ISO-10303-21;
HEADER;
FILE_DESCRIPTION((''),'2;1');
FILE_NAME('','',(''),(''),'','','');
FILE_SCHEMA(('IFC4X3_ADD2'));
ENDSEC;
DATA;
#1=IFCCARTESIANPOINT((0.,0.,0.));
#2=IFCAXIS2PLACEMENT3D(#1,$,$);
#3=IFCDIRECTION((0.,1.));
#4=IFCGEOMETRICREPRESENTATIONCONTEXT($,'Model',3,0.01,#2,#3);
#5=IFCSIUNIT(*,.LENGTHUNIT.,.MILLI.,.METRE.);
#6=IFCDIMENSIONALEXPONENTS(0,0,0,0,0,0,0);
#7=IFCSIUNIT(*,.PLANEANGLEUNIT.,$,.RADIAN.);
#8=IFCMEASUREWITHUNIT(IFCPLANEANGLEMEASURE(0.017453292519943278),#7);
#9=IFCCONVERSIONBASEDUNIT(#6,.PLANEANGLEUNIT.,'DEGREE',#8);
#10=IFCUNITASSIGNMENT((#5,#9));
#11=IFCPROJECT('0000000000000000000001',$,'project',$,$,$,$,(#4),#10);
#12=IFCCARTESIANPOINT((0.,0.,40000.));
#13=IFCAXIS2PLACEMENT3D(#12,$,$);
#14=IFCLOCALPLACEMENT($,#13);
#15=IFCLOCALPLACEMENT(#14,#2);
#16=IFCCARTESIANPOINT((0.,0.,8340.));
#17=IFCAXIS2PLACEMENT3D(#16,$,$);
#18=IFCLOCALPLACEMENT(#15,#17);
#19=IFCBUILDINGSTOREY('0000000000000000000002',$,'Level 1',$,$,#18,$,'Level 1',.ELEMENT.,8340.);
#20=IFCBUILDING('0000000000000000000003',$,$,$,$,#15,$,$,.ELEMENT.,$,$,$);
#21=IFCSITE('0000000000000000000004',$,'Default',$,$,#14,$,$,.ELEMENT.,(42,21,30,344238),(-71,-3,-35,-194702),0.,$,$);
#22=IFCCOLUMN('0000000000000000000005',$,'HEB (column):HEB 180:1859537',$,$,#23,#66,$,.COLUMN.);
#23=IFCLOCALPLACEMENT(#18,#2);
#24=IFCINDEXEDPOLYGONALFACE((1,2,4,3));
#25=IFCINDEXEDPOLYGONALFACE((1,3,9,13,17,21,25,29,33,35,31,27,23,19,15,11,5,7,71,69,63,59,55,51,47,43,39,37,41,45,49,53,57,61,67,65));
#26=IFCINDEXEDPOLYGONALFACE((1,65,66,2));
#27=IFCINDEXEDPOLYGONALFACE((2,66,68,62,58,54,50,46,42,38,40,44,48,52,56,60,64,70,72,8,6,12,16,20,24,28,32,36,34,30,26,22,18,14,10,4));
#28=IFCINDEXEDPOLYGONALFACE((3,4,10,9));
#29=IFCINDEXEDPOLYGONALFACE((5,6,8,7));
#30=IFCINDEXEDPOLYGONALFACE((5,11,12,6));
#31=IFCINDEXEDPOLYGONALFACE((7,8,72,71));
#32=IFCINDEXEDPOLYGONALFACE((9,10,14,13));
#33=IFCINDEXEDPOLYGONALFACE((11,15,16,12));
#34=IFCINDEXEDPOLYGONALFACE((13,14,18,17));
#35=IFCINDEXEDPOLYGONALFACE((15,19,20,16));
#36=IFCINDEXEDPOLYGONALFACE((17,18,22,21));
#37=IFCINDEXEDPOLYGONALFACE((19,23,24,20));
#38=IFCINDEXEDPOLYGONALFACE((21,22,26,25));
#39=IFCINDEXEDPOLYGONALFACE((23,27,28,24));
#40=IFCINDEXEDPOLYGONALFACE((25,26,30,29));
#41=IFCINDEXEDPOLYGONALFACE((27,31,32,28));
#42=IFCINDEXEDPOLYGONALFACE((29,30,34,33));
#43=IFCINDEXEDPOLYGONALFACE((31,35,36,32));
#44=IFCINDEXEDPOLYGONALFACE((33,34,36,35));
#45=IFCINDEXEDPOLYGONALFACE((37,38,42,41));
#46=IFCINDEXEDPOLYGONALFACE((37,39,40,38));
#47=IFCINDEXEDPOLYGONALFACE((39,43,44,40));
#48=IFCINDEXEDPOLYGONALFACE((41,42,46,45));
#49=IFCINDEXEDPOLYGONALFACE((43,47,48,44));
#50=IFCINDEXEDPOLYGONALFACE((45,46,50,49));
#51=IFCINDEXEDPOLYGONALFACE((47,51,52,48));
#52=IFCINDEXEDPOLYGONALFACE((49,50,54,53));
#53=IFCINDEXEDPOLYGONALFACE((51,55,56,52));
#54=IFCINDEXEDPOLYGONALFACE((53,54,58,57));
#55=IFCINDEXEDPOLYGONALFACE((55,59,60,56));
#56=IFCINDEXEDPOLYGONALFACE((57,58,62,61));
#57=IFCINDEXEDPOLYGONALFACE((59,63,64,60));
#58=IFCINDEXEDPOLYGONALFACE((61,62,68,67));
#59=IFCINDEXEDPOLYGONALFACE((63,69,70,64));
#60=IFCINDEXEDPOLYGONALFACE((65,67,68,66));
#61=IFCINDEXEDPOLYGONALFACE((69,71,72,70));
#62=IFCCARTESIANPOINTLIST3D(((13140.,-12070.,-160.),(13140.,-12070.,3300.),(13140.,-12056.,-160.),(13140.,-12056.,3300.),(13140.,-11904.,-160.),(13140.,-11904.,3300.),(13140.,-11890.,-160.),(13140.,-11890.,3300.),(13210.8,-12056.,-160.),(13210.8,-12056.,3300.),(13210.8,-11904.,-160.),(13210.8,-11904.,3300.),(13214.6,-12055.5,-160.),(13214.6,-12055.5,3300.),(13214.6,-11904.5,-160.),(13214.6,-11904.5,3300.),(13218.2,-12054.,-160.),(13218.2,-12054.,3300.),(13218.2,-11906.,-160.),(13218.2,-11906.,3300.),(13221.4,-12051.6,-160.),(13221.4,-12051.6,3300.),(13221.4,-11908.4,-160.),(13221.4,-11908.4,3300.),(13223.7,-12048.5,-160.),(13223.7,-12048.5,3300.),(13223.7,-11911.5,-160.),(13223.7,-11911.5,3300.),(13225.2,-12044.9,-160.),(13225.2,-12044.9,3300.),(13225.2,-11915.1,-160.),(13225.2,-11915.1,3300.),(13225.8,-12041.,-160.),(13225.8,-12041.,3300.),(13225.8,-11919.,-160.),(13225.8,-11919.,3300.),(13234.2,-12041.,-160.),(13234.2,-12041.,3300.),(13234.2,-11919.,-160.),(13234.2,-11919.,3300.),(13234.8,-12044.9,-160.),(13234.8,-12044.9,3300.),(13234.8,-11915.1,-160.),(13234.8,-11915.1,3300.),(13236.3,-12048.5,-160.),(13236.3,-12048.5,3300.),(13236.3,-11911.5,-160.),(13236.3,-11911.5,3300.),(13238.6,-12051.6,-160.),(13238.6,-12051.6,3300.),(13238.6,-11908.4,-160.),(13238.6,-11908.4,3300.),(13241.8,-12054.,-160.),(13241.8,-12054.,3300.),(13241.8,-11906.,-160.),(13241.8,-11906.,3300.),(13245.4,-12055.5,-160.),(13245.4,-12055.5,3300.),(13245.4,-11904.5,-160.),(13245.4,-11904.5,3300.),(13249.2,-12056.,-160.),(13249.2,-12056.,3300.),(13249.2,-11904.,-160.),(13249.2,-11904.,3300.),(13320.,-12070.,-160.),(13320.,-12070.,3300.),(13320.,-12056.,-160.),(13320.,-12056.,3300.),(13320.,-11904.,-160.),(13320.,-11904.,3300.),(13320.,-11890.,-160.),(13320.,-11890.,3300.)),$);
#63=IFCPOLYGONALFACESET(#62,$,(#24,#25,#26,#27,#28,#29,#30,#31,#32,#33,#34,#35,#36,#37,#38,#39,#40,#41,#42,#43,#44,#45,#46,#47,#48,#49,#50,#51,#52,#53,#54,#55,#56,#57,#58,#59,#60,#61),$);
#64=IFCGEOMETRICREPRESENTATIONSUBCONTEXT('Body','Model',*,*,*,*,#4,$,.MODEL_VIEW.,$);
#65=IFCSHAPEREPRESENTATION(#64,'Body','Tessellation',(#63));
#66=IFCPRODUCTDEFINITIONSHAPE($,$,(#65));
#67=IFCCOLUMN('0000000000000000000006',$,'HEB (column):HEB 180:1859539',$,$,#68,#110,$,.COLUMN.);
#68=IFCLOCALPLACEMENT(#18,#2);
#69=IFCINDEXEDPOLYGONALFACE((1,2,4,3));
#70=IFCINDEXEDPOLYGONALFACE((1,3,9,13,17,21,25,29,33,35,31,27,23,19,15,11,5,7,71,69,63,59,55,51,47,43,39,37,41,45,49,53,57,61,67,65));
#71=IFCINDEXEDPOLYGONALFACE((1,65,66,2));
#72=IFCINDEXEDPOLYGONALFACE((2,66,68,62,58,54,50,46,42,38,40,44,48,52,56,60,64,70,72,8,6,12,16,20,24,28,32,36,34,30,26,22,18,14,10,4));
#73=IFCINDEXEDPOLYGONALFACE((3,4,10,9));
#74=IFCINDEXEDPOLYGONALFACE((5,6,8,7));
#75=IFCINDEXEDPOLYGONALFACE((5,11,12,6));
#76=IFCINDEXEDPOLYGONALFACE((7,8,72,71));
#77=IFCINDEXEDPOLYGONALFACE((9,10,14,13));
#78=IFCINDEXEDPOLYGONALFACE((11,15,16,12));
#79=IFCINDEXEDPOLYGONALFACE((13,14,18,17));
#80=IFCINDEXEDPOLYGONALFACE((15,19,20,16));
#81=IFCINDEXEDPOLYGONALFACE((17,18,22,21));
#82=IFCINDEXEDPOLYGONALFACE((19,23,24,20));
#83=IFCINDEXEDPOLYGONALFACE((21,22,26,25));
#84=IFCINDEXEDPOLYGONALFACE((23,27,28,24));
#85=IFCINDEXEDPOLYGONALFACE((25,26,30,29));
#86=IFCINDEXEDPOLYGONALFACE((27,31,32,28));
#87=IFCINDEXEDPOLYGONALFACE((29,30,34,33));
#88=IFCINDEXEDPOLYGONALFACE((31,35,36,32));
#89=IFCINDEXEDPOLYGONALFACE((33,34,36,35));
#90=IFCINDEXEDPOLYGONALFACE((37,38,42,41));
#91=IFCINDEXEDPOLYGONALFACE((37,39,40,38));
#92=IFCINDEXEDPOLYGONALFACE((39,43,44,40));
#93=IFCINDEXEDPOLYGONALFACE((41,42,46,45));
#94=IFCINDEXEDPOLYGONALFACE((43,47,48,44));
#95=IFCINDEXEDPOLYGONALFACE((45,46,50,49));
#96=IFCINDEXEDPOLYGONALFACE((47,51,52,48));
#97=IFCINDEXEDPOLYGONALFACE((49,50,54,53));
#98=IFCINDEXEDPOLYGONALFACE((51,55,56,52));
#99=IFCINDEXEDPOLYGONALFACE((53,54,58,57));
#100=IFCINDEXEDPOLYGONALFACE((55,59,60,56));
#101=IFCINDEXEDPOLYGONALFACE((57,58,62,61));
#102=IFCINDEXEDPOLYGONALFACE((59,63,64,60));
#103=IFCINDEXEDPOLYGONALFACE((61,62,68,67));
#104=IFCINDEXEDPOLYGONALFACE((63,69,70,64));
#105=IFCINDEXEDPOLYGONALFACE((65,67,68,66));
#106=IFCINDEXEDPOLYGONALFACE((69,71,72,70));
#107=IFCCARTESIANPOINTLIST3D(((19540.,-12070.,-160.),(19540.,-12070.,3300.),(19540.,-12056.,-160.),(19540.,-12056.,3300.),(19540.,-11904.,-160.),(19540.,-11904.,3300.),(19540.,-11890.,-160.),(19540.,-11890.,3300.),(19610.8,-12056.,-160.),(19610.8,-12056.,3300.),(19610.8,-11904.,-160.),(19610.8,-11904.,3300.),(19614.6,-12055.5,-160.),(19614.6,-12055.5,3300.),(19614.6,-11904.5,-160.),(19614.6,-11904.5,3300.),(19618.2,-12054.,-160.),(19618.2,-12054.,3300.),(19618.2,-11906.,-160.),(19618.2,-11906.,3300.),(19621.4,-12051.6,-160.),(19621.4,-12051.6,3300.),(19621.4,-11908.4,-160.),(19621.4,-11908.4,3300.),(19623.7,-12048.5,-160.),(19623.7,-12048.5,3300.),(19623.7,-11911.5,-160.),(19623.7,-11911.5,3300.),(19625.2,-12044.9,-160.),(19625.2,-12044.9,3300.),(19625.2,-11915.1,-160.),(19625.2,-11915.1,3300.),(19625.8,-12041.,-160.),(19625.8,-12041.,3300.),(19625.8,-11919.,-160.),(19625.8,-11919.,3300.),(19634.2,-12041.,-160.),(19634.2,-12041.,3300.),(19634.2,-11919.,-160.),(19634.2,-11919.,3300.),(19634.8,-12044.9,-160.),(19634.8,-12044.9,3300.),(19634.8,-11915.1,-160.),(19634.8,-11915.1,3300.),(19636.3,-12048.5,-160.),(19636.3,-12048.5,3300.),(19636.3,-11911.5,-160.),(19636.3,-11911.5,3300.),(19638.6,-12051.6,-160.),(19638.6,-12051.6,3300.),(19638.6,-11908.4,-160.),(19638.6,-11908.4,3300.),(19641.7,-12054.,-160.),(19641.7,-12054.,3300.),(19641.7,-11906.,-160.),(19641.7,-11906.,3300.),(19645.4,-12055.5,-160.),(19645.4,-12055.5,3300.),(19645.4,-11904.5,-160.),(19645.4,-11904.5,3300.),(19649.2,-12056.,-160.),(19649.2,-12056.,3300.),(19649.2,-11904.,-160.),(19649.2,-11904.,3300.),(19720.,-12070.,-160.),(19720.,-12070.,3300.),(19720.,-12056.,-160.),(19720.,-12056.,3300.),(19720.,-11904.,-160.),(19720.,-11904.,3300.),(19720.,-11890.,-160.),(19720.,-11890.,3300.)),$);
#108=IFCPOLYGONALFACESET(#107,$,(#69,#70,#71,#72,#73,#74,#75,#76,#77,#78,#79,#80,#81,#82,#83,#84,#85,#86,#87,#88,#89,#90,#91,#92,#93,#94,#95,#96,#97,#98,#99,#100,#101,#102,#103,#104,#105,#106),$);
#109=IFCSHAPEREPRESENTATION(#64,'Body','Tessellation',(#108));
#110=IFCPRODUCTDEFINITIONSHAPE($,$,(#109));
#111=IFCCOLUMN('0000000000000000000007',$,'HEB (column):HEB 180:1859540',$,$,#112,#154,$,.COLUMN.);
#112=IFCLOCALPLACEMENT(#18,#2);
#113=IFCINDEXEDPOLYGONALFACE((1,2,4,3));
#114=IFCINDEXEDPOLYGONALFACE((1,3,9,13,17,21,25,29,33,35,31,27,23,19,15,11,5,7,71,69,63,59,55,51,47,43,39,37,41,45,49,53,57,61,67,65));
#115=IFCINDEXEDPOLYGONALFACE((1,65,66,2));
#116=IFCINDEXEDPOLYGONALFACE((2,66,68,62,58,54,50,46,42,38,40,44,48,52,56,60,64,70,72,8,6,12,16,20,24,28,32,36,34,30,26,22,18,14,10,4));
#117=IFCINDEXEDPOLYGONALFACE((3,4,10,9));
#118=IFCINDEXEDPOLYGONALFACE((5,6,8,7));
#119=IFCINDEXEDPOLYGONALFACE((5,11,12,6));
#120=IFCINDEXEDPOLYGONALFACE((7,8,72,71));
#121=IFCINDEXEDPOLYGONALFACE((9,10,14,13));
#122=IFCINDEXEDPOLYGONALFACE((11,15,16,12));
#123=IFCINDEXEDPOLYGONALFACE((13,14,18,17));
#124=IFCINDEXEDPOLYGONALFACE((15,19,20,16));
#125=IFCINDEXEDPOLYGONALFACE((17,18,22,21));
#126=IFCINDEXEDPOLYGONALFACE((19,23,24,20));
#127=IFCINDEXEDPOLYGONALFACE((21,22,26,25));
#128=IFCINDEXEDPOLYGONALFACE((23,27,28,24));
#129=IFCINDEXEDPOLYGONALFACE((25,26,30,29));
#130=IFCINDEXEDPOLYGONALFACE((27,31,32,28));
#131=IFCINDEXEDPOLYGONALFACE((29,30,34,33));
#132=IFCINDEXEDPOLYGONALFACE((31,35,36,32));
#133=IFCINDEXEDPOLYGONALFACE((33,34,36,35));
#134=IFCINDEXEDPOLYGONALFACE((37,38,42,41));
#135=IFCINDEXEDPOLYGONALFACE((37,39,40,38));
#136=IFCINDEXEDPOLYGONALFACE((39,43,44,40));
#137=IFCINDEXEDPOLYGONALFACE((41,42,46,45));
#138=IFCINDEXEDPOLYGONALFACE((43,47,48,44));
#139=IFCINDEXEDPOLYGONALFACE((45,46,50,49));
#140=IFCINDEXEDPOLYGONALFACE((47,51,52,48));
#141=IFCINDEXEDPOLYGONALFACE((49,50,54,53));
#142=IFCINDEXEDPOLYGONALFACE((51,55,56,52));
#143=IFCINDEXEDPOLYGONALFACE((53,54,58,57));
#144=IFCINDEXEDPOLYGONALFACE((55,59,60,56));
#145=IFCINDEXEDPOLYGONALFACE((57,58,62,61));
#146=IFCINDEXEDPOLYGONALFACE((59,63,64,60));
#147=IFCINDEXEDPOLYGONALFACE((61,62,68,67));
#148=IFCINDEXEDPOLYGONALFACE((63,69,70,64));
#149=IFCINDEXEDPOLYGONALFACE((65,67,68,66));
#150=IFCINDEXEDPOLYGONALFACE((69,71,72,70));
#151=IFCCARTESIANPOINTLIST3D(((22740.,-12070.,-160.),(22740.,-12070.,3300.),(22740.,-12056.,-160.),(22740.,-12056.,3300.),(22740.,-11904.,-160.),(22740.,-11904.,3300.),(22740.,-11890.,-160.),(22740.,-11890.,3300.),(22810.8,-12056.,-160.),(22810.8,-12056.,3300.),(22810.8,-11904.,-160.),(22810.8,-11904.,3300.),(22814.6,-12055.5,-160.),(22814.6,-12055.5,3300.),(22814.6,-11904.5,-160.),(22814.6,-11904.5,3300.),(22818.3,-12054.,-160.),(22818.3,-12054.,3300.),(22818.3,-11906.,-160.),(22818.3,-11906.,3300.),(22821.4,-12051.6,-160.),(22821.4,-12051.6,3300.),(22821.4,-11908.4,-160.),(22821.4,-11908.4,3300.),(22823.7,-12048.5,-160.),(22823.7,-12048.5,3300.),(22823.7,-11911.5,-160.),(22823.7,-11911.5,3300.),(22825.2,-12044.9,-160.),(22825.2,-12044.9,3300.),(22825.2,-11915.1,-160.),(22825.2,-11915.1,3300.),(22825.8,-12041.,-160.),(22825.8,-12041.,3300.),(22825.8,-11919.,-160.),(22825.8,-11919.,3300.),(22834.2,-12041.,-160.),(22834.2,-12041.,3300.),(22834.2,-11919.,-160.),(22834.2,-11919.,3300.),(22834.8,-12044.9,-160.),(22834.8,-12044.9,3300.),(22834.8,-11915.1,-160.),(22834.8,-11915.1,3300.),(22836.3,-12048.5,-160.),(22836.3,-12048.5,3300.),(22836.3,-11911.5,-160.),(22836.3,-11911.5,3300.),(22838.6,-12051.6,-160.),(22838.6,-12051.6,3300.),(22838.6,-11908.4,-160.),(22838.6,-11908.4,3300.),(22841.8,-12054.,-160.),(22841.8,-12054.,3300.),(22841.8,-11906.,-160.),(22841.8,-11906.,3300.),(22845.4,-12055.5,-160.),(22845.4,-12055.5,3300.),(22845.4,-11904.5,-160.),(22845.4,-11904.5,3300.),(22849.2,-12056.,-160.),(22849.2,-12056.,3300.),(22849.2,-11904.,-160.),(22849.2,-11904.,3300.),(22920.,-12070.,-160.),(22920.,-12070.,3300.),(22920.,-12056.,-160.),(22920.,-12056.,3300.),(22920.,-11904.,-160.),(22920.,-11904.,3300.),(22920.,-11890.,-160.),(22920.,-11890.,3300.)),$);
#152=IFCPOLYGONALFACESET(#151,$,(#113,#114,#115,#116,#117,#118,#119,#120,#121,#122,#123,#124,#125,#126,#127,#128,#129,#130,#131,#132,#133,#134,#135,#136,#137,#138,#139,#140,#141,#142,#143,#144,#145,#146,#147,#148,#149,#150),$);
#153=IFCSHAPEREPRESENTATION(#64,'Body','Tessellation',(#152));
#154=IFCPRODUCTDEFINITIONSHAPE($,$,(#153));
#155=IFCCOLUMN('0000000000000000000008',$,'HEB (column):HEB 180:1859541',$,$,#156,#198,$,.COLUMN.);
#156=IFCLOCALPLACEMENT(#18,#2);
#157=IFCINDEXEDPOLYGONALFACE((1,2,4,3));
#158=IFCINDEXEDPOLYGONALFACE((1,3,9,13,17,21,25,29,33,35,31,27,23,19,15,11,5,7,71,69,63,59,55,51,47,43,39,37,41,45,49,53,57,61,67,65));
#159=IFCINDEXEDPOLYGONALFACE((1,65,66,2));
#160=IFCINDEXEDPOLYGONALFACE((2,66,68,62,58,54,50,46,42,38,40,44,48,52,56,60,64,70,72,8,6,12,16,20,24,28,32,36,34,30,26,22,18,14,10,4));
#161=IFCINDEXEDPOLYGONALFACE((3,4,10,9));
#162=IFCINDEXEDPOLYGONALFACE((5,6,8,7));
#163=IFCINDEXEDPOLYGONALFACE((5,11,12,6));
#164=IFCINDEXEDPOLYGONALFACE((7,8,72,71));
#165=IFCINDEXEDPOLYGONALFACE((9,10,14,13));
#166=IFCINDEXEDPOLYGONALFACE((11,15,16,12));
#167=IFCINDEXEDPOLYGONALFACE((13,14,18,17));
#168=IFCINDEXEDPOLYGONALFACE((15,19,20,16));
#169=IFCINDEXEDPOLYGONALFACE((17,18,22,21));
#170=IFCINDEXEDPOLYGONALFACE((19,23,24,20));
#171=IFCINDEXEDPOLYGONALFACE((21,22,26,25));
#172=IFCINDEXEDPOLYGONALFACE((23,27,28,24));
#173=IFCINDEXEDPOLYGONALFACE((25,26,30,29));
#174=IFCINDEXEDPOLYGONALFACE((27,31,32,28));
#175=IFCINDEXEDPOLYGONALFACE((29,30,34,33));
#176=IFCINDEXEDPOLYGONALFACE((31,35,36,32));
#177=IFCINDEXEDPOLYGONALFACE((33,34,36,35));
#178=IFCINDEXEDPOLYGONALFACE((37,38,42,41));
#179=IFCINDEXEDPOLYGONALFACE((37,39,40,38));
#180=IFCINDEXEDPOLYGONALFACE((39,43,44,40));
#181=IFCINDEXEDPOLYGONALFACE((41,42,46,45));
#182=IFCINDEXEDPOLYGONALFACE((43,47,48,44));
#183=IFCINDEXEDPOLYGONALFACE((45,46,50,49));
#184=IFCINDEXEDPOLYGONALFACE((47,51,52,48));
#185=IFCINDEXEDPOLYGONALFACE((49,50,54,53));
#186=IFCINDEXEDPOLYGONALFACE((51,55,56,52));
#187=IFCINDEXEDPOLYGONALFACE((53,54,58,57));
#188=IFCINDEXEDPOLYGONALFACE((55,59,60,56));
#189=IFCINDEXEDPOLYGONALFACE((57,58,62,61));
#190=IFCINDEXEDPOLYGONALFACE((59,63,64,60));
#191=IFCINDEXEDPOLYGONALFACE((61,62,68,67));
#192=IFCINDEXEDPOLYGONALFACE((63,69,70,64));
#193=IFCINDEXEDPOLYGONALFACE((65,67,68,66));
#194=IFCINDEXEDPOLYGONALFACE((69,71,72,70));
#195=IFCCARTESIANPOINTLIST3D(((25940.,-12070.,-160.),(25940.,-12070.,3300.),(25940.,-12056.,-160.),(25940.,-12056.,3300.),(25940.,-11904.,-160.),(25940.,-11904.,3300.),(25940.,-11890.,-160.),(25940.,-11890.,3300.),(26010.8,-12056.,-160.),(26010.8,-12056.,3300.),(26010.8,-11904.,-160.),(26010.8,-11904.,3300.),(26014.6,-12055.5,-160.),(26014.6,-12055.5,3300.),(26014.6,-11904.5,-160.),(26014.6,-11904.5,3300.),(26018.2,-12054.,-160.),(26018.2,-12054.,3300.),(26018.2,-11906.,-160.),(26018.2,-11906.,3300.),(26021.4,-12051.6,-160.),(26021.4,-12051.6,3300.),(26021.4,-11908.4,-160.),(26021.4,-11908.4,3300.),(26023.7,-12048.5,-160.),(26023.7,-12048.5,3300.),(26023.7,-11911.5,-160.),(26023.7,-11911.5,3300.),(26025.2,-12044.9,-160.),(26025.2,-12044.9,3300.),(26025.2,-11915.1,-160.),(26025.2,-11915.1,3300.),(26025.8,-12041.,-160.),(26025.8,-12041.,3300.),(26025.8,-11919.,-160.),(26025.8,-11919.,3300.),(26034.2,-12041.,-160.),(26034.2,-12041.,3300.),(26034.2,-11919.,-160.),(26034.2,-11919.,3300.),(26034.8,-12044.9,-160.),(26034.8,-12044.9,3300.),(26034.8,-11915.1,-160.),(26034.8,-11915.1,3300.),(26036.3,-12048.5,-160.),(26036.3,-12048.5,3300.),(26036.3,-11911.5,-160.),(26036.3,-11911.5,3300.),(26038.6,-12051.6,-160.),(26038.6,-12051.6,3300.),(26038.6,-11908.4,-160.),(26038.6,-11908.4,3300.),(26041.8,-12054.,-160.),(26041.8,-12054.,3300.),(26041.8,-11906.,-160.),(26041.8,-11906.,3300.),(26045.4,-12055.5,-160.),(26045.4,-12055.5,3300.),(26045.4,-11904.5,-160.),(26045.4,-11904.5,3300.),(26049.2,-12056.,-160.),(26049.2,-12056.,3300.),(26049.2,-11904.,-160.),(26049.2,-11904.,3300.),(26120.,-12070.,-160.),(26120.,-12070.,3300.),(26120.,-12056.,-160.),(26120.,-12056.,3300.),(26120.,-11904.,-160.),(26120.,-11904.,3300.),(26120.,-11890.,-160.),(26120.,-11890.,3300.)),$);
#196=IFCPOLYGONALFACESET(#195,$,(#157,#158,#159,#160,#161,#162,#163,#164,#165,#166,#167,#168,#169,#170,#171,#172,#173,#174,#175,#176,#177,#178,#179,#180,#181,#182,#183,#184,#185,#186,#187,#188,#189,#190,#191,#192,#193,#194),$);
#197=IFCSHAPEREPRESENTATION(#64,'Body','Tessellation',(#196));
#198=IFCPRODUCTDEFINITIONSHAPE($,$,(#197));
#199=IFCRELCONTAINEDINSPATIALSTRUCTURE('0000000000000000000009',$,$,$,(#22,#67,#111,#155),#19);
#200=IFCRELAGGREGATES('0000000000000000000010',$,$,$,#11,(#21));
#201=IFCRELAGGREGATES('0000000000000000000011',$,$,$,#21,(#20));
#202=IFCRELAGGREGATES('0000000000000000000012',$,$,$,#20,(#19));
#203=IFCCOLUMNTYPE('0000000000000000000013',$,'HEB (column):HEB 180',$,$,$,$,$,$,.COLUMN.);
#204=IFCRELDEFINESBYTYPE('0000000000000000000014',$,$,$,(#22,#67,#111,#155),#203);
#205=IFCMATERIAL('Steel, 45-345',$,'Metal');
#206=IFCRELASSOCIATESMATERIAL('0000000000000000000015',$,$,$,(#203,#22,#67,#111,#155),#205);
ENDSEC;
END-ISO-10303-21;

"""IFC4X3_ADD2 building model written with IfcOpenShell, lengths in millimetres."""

from ifc_helpers import new_model, entity, si_unit, converted_unit, direction, frame, origin, origin_2d_with_axis, place, context, subcontext, project, spatial, i_section, extrude, source, transform, mapped, material, material_profile, profile_set, profile_usage, type_object, type_shapes, element, save


model = new_model("IFC4X3_ADD2")

# Units and contexts
model_context = context("Model", 3, precision=0.01, world=origin(), true_north=direction((0.0, 1.0)))
body_context = subcontext(model_context, "Body", "Model", "MODEL_VIEW")
ifc_project = project(units=[si_unit("LENGTHUNIT", "METRE", prefix="MILLI"), converted_unit("PLANEANGLEUNIT", "DEGREE", entity("IfcPlaneAngleMeasure", 0.017453292519943278), si_unit("PLANEANGLEUNIT", "RADIAN"), dimensions=[0, 0, 0, 0, 0, 0, 0])], contexts=[model_context])

# Site, building, storey
site_placement = place(None, frame((0.0, 0.0, 40000.0)))
site = spatial("IfcSite", under=ifc_project, at=site_placement, Name="Default", CompositionType="ELEMENT", RefLatitude=(42, 21, 30, 344238), RefLongitude=(-71, -3, -35, -194702), RefElevation=0.0)
building_placement = place(site_placement, origin())
building = spatial("IfcBuilding", under=site, at=building_placement, CompositionType="ELEMENT")
storey_placement = place(building_placement, frame((0.0, 0.0, 8340.0)))
storey = spatial("IfcBuildingStorey", under=building, at=storey_placement, Name="Level 1", LongName="Level 1", CompositionType="ELEMENT", Elevation=8340.0)

# Columns
ifc_material_1 = material(Name="Steel, 45-345", Category="Metal")
ifc_material_profile_1 = material_profile(ifc_material_1, i_section(OverallWidth=180.0, OverallDepth=180.0, WebThickness=8.5, FlangeThickness=14.0, FilletRadius=15.0, at=origin_2d_with_axis()), Name="HEB 180")
ifc_profile_set_1 = profile_set([ifc_material_profile_1], Name="HEB 180")
ifc_profile_usage_1 = profile_usage(ifc_profile_set_1)
column_type = type_object("IfcColumnType", Name="HEB (column):HEB 180", PredefinedType="COLUMN", material=ifc_profile_set_1)
shared_shape_1 = source(origin(), body_context, "Body", "SweptSolid", [
    extrude(i_section(OverallWidth=180.0, OverallDepth=180.0, WebThickness=8.5, FlangeThickness=14.0, FilletRadius=15.0, at=origin_2d_with_axis()), frame((0.0, 0.0, 8180.0), z_axis=(0.0, 0.0, 1.0), x_axis=(-1.0, 0.0, 0.0)), (0.0, 0.0, 1.0), 3460.0),
])
type_shapes(column_type, [shared_shape_1])
column_placement = place(storey_placement, frame((13230.0, -11980.0, -8340.0), z_axis=(0.0, 0.0, 1.0), x_axis=(-1.0, 0.0, 0.0)))
element("IfcColumn", 1, at=column_placement, inside=storey, type_object=column_type, material=ifc_profile_usage_1, Name="HEB (column):HEB 180:1859537", PredefinedType="COLUMN", context=body_context, shape_type="MappedRepresentation", body=[
    mapped(shared_shape_1, transform((0.0, 0.0, 0.0), scale=1.0)),
])
for number, where, name in (
    (2, (19630.0, -11980.0, -8340.0), "HEB (column):HEB 180:1859539"),
    (3, (22830.0, -11980.0, -8340.0), "HEB (column):HEB 180:1859540"),
    (4, (26030.0, -11980.0, -8340.0), "HEB (column):HEB 180:1859541"),
):
    element("IfcColumn", number, at=place(storey_placement, frame(where)), inside=storey, type_object=column_type, material=ifc_profile_usage_1, Name=name, PredefinedType="COLUMN", context=body_context, shape_type="MappedRepresentation", body=[
        mapped(shared_shape_1, transform((0.0, 0.0, 0.0), scale=1.0)),
    ])

save(model, "model.ifc")
